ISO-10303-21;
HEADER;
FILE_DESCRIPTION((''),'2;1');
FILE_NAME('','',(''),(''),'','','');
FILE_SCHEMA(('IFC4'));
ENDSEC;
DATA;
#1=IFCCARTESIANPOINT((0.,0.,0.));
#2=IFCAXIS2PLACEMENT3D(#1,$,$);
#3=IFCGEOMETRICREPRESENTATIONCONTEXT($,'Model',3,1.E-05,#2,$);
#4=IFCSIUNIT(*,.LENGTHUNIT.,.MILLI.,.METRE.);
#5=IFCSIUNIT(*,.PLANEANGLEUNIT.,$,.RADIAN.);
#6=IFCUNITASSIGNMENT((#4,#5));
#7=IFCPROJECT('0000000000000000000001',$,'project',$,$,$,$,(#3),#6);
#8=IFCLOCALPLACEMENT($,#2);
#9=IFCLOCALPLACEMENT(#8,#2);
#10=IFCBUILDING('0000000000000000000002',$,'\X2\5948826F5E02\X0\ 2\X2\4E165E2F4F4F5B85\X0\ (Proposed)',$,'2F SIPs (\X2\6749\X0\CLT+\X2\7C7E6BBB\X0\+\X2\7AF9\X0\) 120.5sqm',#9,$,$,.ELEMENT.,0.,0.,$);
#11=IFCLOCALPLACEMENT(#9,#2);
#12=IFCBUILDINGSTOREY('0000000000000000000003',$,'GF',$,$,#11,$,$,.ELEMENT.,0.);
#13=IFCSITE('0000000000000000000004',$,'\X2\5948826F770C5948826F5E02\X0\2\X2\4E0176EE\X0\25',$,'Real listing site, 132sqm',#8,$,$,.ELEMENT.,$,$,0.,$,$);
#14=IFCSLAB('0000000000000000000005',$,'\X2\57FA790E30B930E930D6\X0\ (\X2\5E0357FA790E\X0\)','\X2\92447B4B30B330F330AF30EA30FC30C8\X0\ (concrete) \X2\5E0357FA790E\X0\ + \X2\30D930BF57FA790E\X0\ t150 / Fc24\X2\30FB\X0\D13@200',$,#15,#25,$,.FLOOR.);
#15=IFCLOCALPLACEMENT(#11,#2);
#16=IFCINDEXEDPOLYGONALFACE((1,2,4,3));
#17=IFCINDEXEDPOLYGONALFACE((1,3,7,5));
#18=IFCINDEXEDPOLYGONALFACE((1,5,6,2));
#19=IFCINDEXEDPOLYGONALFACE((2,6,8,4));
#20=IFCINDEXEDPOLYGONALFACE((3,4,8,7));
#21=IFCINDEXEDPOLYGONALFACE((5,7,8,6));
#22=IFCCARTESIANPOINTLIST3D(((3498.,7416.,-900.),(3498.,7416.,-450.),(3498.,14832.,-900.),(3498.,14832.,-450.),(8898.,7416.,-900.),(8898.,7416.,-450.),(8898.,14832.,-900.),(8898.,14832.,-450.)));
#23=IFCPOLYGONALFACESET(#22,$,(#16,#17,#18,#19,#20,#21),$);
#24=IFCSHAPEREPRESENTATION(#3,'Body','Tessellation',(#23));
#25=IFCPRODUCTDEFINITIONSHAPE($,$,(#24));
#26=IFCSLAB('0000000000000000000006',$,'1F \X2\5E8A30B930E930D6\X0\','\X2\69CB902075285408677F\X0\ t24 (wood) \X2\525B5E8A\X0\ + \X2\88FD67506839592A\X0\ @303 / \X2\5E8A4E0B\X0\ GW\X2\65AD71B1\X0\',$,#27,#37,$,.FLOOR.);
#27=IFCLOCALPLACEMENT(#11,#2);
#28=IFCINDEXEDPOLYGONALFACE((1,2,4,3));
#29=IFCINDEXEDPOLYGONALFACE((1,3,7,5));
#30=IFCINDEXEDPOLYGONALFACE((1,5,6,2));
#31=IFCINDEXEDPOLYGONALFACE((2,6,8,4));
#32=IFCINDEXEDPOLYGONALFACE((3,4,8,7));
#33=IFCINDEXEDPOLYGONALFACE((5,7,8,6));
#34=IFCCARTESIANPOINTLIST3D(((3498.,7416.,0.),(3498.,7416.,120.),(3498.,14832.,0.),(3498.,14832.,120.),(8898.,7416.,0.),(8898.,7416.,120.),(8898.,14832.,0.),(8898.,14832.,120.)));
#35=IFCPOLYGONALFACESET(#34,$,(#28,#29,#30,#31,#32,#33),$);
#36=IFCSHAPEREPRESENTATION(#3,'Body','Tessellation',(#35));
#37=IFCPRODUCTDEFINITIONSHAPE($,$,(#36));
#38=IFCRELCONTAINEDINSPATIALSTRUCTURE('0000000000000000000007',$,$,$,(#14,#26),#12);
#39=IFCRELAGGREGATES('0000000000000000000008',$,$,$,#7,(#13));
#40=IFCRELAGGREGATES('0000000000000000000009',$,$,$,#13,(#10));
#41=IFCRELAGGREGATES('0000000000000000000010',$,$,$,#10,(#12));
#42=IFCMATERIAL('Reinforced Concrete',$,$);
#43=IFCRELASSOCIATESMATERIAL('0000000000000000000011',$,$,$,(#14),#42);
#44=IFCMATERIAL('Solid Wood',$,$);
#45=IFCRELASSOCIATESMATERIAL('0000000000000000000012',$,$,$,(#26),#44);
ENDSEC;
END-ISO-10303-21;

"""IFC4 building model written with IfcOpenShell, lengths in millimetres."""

from ifc_helpers import new_model, si_unit, frame, frame_2d, origin, place, context, project, spatial, rectangle, extrude, material, element, save


model = new_model("IFC4")

# Units and contexts
model_context = context("Model", 3, precision=1e-05, world=origin())
ifc_project = project(units=[si_unit("LENGTHUNIT", "METRE", prefix="MILLI"), si_unit("PLANEANGLEUNIT", "RADIAN")], contexts=[model_context])

# Site, building, storey
site_placement = place(None, origin())
site = spatial("IfcSite", under=ifc_project, at=site_placement, Name="奈良県奈良市2丁目25", ObjectType="Real listing site, 132sqm", CompositionType="ELEMENT", RefElevation=0.0)
building_placement = place(site_placement, origin())
building = spatial("IfcBuilding", under=site, at=building_placement, Name="奈良市 2世帯住宅 (Proposed)", ObjectType="2F SIPs (杉CLT+籾殻+竹) 120.5sqm", CompositionType="ELEMENT", ElevationOfRefHeight=0.0, ElevationOfTerrain=0.0)
storey_placement = place(building_placement, origin())
storey = spatial("IfcBuildingStorey", under=building, at=storey_placement, Name="GF", CompositionType="ELEMENT", Elevation=0.0)

# Slabs
ifc_material_1 = material(Name="Reinforced Concrete")
slab_1_placement = place(storey_placement, frame((1749.0, 3708.0, -450.0)))
element("IfcSlab", 1, at=slab_1_placement, inside=storey, material=ifc_material_1, Name="基礎スラブ (布基礎)", Description="鉄筋コンクリート (concrete) 布基礎 + ベタ基礎 t150 / Fc24・D13@200", PredefinedType="FLOOR", context=model_context, shape_type="SweptSolid", body=[
    extrude(rectangle(XDim=5400.0, YDim=7416.0, at=frame_2d((2700.0, 3708.0))), frame((1749.0, 3708.0, -450.0)), (0.0, 0.0, 1.0), 450.0),
])
ifc_material_2 = material(Name="Solid Wood")
slab_2_placement = place(storey_placement, frame((1749.0, 3708.0, 0.0)))
element("IfcSlab", 2, at=slab_2_placement, inside=storey, material=ifc_material_2, Name="1F 床スラブ", Description="構造用合板 t24 (wood) 剛床 + 製材根太 @303 / 床下 GW断熱", PredefinedType="FLOOR", context=model_context, shape_type="SweptSolid", body=[
    extrude(rectangle(XDim=5400.0, YDim=7416.0, at=frame_2d((2700.0, 3708.0))), frame((1749.0, 3708.0, 0.0)), (0.0, 0.0, 1.0), 120.0),
])

save(model, "model.ifc")
